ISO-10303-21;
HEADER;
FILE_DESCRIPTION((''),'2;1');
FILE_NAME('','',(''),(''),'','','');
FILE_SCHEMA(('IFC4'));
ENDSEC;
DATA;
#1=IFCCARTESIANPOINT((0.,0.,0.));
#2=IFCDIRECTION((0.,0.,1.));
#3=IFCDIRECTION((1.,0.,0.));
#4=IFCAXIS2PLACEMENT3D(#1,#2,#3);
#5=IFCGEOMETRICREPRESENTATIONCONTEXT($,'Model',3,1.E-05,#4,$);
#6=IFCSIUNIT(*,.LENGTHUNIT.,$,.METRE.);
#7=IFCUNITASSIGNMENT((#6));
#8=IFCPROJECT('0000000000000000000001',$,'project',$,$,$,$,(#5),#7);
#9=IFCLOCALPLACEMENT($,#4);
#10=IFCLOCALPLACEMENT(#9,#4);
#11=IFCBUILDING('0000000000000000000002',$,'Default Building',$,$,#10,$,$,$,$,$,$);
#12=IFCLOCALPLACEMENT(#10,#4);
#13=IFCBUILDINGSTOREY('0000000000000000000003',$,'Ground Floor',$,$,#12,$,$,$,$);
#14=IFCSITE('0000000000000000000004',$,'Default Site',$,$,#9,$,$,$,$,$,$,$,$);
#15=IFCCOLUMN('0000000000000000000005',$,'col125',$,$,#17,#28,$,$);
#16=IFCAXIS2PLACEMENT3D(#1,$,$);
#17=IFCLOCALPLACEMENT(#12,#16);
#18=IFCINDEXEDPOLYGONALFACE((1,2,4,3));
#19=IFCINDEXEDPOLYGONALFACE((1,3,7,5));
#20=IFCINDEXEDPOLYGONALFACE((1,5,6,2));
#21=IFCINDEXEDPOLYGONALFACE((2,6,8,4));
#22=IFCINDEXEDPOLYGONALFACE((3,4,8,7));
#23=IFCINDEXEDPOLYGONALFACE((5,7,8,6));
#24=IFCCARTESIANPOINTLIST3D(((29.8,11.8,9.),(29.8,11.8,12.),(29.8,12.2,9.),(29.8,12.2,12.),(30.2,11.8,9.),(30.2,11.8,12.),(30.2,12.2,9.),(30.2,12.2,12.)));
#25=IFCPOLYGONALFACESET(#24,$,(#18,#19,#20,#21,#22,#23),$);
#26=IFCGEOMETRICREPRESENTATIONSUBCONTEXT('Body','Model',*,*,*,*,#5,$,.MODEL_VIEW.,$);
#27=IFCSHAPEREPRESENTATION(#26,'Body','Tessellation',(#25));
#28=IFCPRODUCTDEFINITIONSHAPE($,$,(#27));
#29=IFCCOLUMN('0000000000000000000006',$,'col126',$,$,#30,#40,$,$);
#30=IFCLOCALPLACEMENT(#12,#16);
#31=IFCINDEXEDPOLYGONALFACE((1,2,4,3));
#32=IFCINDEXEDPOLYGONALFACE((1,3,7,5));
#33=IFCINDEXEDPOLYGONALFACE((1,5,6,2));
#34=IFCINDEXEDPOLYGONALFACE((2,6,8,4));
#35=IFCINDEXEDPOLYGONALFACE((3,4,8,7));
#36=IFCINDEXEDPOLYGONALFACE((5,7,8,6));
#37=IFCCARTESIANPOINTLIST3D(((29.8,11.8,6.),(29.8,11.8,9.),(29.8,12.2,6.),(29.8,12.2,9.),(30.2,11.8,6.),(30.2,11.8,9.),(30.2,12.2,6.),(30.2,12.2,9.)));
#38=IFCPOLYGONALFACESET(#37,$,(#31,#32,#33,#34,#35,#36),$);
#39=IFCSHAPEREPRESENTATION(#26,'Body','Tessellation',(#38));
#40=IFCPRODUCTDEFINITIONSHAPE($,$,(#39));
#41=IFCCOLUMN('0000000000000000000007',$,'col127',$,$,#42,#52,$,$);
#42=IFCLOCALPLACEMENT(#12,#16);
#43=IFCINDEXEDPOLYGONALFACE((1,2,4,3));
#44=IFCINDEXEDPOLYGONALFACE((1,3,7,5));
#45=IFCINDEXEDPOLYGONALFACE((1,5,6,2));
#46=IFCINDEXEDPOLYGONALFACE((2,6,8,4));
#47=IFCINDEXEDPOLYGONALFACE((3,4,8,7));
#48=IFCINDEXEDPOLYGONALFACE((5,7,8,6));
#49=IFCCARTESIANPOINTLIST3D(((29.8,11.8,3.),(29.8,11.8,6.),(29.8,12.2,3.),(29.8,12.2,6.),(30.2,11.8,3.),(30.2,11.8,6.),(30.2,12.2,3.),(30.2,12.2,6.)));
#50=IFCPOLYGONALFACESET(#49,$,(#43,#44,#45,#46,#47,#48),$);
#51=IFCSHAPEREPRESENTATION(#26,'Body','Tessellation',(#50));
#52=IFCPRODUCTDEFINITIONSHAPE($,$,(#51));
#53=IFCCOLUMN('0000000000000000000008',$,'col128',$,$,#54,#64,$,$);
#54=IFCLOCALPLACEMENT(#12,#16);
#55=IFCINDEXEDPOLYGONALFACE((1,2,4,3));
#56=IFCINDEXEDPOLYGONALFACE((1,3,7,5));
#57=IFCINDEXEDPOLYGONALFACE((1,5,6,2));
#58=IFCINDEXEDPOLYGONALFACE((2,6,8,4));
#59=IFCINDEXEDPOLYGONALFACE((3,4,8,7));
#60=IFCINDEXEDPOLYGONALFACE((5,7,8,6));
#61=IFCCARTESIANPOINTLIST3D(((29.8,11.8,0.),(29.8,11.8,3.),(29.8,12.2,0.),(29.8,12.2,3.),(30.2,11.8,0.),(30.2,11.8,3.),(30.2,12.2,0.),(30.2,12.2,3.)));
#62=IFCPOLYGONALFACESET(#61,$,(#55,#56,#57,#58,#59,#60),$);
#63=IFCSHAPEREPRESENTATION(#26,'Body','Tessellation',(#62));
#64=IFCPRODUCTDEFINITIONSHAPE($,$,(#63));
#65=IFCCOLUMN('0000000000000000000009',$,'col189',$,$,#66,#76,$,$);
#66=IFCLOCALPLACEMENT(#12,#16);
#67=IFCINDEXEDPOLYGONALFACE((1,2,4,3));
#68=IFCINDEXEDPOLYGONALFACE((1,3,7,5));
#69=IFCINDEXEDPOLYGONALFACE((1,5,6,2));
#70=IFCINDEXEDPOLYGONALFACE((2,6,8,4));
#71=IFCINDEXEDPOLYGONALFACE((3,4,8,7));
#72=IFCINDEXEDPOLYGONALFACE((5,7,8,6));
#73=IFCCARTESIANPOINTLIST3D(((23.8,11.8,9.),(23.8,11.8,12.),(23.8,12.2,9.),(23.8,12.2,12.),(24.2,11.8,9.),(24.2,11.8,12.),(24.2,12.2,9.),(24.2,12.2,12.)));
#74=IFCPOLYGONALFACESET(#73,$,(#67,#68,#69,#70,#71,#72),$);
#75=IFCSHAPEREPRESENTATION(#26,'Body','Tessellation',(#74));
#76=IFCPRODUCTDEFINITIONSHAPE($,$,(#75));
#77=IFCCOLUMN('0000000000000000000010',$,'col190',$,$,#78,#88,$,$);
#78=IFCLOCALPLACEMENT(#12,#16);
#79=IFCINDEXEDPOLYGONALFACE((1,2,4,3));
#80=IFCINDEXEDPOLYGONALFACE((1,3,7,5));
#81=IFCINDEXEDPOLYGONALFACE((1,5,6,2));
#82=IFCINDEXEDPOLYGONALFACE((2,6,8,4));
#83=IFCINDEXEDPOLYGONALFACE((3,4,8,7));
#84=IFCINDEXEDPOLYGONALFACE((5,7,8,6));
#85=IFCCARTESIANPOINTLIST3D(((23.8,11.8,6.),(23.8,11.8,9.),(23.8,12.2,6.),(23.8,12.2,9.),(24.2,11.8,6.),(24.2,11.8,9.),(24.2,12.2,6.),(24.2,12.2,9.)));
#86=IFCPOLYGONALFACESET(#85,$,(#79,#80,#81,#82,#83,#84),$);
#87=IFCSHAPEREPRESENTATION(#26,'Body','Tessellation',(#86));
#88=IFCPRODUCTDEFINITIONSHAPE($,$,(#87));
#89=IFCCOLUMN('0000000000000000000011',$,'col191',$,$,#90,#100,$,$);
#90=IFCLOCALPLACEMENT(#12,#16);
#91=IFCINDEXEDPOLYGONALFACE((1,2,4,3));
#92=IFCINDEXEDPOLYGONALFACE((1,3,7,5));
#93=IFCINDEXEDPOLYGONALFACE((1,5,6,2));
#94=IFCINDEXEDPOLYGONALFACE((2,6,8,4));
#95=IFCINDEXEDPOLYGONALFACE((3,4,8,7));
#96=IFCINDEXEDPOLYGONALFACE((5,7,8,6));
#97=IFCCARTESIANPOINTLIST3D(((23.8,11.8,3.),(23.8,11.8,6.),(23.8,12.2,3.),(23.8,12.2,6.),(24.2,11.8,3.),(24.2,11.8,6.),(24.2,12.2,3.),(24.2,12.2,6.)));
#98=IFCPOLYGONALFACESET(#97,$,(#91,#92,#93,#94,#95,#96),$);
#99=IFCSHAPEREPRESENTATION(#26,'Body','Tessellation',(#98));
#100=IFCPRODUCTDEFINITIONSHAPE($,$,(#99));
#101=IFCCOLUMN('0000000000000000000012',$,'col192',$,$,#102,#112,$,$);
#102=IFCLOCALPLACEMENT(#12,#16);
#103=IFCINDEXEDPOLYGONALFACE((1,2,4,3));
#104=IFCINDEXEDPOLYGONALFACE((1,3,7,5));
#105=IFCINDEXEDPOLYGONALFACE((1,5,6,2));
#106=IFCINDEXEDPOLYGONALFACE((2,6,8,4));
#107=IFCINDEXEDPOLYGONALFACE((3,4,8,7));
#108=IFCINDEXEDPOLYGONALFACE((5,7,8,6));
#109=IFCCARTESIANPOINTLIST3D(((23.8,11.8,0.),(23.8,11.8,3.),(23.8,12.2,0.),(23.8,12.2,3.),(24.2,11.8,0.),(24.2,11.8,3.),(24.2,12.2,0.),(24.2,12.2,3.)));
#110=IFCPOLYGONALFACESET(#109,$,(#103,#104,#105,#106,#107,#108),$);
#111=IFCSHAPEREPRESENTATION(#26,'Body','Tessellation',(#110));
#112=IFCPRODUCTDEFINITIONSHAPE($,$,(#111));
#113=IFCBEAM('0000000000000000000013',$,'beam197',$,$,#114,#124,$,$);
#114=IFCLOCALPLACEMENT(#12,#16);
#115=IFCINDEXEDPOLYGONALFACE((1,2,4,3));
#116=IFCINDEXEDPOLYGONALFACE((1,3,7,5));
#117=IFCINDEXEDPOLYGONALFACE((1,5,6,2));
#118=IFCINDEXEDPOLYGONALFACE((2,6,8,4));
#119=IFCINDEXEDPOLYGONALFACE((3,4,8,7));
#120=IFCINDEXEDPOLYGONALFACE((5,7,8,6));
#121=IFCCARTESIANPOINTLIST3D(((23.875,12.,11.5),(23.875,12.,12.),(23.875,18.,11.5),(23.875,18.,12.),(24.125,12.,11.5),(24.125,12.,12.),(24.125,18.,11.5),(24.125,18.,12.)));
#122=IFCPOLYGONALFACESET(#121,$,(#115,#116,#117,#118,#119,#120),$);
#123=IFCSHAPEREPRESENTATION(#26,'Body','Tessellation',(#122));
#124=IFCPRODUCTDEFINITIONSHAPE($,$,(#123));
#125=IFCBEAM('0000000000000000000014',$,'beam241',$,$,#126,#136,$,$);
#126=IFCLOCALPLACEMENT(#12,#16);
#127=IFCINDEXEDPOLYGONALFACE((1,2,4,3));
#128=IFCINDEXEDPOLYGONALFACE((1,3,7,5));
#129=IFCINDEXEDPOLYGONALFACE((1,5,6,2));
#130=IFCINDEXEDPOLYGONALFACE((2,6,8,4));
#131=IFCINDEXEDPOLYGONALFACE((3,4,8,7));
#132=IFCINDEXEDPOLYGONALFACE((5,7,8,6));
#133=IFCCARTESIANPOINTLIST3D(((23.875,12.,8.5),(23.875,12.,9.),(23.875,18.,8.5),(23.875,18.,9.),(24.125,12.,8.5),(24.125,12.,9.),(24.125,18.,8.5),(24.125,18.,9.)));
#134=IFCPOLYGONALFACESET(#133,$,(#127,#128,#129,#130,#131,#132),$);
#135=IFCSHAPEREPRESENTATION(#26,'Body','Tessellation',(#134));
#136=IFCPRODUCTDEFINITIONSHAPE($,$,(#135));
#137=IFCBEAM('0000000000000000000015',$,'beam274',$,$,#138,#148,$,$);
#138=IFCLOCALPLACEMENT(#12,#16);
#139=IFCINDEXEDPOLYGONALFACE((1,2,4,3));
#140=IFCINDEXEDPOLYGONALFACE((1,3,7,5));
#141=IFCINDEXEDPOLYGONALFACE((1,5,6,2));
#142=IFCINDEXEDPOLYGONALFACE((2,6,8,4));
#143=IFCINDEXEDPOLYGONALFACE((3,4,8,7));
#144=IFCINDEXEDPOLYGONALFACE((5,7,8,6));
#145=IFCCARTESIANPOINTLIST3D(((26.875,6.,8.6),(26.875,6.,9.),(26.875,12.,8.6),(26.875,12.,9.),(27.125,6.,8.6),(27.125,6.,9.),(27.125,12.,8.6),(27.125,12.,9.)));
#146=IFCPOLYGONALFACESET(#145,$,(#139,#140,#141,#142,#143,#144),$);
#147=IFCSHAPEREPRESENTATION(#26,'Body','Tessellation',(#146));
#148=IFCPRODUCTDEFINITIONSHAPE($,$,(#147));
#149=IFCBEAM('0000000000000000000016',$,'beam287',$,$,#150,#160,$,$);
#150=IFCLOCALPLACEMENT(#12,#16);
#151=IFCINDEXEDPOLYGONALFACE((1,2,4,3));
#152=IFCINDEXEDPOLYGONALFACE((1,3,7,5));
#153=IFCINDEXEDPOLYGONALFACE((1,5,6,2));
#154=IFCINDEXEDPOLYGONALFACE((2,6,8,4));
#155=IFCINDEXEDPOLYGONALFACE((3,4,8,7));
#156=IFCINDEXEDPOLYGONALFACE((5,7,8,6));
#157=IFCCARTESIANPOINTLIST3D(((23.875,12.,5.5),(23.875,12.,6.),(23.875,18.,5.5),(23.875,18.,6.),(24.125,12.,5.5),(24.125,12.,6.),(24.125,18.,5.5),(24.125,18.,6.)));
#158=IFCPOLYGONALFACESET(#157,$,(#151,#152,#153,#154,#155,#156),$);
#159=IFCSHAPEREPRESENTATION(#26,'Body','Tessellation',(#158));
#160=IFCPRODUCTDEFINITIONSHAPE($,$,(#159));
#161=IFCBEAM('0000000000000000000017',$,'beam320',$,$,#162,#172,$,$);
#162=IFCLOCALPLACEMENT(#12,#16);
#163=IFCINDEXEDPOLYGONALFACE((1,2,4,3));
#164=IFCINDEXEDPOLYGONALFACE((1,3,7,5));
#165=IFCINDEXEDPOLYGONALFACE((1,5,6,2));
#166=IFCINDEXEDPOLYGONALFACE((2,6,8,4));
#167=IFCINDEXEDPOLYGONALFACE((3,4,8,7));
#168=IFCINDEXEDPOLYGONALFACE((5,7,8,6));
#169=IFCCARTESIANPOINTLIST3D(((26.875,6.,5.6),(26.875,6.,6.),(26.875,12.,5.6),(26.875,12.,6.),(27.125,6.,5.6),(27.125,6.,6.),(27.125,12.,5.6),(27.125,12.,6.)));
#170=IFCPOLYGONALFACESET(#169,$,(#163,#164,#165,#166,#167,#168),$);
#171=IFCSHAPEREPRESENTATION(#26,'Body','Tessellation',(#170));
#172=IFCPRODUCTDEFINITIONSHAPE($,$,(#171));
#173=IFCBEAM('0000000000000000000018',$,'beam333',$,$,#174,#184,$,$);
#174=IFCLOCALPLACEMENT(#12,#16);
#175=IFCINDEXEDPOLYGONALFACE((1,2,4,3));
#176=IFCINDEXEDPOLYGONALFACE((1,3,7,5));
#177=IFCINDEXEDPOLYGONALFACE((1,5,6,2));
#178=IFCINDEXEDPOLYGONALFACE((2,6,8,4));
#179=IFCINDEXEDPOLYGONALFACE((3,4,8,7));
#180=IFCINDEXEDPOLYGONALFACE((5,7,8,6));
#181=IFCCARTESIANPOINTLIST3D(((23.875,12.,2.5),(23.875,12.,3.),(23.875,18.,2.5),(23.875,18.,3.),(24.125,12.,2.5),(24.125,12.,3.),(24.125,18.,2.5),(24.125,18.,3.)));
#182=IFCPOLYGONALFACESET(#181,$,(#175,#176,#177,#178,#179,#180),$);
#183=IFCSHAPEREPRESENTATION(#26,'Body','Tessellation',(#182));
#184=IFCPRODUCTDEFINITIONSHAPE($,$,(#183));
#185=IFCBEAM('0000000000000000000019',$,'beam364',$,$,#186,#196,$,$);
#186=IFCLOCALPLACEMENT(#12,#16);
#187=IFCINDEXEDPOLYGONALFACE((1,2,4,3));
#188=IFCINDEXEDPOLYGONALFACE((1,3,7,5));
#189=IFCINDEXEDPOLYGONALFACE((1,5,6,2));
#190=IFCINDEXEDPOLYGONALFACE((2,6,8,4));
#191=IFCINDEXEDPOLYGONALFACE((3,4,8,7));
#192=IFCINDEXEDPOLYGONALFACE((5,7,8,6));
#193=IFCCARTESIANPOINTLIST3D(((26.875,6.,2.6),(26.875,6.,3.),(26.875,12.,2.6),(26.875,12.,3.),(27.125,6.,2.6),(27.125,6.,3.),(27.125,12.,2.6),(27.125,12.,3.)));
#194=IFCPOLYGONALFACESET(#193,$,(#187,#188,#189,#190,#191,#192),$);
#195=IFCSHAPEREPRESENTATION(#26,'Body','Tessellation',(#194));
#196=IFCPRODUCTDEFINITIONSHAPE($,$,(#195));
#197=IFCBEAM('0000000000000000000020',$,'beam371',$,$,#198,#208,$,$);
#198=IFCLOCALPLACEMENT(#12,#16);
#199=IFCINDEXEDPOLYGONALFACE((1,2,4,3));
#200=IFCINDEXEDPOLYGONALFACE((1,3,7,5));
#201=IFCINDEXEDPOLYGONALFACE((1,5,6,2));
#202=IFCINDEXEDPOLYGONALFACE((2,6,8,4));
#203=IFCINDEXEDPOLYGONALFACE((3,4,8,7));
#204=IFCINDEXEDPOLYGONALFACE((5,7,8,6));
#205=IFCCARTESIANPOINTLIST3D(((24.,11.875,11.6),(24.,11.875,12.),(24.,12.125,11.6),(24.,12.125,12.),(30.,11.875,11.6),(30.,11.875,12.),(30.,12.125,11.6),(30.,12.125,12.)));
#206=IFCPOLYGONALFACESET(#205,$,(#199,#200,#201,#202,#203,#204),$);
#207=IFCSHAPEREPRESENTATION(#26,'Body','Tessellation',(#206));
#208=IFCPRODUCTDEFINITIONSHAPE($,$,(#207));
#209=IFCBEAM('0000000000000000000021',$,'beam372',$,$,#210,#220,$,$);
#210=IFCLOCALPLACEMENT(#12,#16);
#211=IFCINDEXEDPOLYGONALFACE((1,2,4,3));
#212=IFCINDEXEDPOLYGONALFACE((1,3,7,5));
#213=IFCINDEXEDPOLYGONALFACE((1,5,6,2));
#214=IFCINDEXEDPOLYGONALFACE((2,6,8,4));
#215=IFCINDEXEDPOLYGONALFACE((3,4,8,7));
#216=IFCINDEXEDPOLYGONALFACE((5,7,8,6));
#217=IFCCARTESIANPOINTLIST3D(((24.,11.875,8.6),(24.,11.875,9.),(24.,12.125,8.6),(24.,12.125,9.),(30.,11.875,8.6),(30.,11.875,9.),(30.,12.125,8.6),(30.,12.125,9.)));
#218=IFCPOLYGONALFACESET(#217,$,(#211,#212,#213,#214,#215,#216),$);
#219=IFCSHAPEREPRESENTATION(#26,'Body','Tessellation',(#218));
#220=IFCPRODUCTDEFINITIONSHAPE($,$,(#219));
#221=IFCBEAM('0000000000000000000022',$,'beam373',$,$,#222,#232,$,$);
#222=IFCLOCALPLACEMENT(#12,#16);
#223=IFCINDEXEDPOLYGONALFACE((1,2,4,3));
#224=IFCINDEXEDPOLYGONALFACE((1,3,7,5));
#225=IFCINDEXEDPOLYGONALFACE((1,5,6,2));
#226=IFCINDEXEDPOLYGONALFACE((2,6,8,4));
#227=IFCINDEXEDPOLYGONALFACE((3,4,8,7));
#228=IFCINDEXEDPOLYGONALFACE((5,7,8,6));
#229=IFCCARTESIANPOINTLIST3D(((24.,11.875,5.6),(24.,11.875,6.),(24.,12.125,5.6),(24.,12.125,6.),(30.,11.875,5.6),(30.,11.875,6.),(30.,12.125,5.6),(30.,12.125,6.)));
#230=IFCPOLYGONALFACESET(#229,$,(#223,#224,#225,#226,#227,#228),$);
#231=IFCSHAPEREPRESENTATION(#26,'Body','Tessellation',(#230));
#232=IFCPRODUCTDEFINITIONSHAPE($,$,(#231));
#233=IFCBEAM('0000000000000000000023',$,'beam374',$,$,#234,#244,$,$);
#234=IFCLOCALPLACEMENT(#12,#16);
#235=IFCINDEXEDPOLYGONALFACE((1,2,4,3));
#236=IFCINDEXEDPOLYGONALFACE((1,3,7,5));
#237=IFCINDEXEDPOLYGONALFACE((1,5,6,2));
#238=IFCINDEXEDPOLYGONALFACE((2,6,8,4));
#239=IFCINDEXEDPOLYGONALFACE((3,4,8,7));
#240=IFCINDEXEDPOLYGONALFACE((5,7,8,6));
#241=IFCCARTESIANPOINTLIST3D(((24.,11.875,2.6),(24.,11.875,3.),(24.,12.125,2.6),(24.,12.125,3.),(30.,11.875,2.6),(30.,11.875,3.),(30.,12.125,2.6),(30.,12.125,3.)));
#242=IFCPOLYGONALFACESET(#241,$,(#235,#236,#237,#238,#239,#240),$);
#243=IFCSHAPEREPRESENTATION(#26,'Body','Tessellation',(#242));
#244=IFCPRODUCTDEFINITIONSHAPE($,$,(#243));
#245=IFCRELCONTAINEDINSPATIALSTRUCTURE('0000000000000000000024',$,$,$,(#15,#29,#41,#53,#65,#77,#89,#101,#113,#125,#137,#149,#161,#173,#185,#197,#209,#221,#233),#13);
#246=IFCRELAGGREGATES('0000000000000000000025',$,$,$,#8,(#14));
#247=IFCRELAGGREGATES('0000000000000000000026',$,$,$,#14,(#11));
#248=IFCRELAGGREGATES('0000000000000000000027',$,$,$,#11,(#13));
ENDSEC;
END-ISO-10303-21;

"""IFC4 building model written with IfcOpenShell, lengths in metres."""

from ifc_helpers import new_model, si_unit, frame, origin_with_axes, place, context, subcontext, project, spatial, indexed_curve, outline, extrude, element, save


model = new_model("IFC4")

# Units and contexts
model_context = context("Model", 3, precision=1e-05, world=origin_with_axes())
body_context = subcontext(model_context, "Body", "Model", "MODEL_VIEW")
ifc_project = project(units=[si_unit("LENGTHUNIT", "METRE")], contexts=[model_context])

# Site, building, storey
site_placement = place(None, origin_with_axes())
site = spatial("IfcSite", under=ifc_project, at=site_placement, Name="Default Site")
building_placement = place(site_placement, origin_with_axes())
building = spatial("IfcBuilding", under=site, at=building_placement, Name="Default Building")
storey_placement = place(building_placement, origin_with_axes())
storey = spatial("IfcBuildingStorey", under=building, at=storey_placement, Name="Ground Floor")

# Columns
for number, where, z_axis, x_axis, name in (
    (1, (29.8, 11.8, 9.0), (0.0, 0.0, 1.0), (1.0, 0.0, 0.0), "col125"),
    (2, (29.8, 11.8, 6.0), (0.0, 0.0, 1.0), (1.0, 0.0, 0.0), "col126"),
    (3, (29.8, 11.8, 3.0), (0.0, 0.0, 1.0), (1.0, 0.0, 0.0), "col127"),
    (4, (29.8, 11.8, 0.0), (0.0, 0.0, 1.0), (1.0, 0.0, 0.0), "col128"),
    (5, (23.8, 11.8, 9.0), (0.0, 0.0, 1.0), (1.0, 0.0, 0.0), "col189"),
    (6, (23.8, 11.8, 6.0), (0.0, 0.0, 1.0), (1.0, 0.0, 0.0), "col190"),
    (7, (23.8, 11.8, 3.0), (0.0, 0.0, 1.0), (1.0, 0.0, 0.0), "col191"),
    (8, (23.8, 11.8, 0.0), (0.0, 0.0, 1.0), (1.0, 0.0, 0.0), "col192"),
):
    element("IfcColumn", number, at=place(storey_placement, frame(where, z_axis=z_axis, x_axis=x_axis)), inside=storey, Name=name, context=body_context, shape_type="SweptSolid", body=[
        extrude(outline(indexed_curve([(0.0, 0.0), (0.0, 0.4), (0.4, 0.4), (0.4, 0.0), (0.0, 0.0)], self_intersect=False)), origin_with_axes(), (0.0, 0.0, 1.0), 3.0),
    ])

# Beams
for number, where, z_axis, x_axis, name in (
    (9, (24.125, 12.0, 11.5), (0.0, 0.0, 1.0), (0.0, 1.0, 0.0), "beam197"),
    (10, (24.125, 12.0, 8.5), (0.0, 0.0, 1.0), (0.0, 1.0, 0.0), "beam241"),
):
    element("IfcBeam", number, at=place(storey_placement, frame(where, z_axis=z_axis, x_axis=x_axis)), inside=storey, Name=name, context=body_context, shape_type="SweptSolid", body=[
        extrude(outline(indexed_curve([(0.0, 0.0), (0.0, 0.25), (6.0, 0.25), (6.0, 0.0), (0.0, 0.0)], self_intersect=False)), origin_with_axes(), (0.0, 0.0, 1.0), 0.5),
    ])
beam_1_placement = place(storey_placement, frame((26.875, 12.0, 8.6), z_axis=(0.0, 0.0, 1.0), x_axis=(0.0, -1.0, 0.0)))
element("IfcBeam", 11, at=beam_1_placement, inside=storey, Name="beam274", context=body_context, shape_type="SweptSolid", body=[
    extrude(outline(indexed_curve([(0.0, 0.0), (0.0, 0.25), (6.0, 0.25), (6.0, 0.0), (0.0, 0.0)], self_intersect=False)), origin_with_axes(), (0.0, 0.0, 1.0), 0.4),
])
beam_2_placement = place(storey_placement, frame((24.125, 12.0, 5.5), z_axis=(0.0, 0.0, 1.0), x_axis=(0.0, 1.0, 0.0)))
element("IfcBeam", 12, at=beam_2_placement, inside=storey, Name="beam287", context=body_context, shape_type="SweptSolid", body=[
    extrude(outline(indexed_curve([(0.0, 0.0), (0.0, 0.25), (6.0, 0.25), (6.0, 0.0), (0.0, 0.0)], self_intersect=False)), origin_with_axes(), (0.0, 0.0, 1.0), 0.5),
])
beam_3_placement = place(storey_placement, frame((26.875, 12.0, 5.6), z_axis=(0.0, 0.0, 1.0), x_axis=(0.0, -1.0, 0.0)))
element("IfcBeam", 13, at=beam_3_placement, inside=storey, Name="beam320", context=body_context, shape_type="SweptSolid", body=[
    extrude(outline(indexed_curve([(0.0, 0.0), (0.0, 0.25), (6.0, 0.25), (6.0, 0.0), (0.0, 0.0)], self_intersect=False)), origin_with_axes(), (0.0, 0.0, 1.0), 0.4),
])
beam_4_placement = place(storey_placement, frame((24.125, 12.0, 2.5), z_axis=(0.0, 0.0, 1.0), x_axis=(0.0, 1.0, 0.0)))
element("IfcBeam", 14, at=beam_4_placement, inside=storey, Name="beam333", context=body_context, shape_type="SweptSolid", body=[
    extrude(outline(indexed_curve([(0.0, 0.0), (0.0, 0.25), (6.0, 0.25), (6.0, 0.0), (0.0, 0.0)], self_intersect=False)), origin_with_axes(), (0.0, 0.0, 1.0), 0.5),
])
for number, where, z_axis, x_axis, name in (
    (15, (26.875, 12.0, 2.6), (0.0, 0.0, 1.0), (0.0, -1.0, 0.0), "beam364"),
    (16, (24.0, 11.875, 11.6), (0.0, 0.0, 1.0), (1.0, 0.0, 0.0), "beam371"),
    (17, (24.0, 11.875, 8.6), (0.0, 0.0, 1.0), (1.0, 0.0, 0.0), "beam372"),
    (18, (24.0, 11.875, 5.6), (0.0, 0.0, 1.0), (1.0, 0.0, 0.0), "beam373"),
    (19, (24.0, 11.875, 2.6), (0.0, 0.0, 1.0), (1.0, 0.0, 0.0), "beam374"),
):
    element("IfcBeam", number, at=place(storey_placement, frame(where, z_axis=z_axis, x_axis=x_axis)), inside=storey, Name=name, context=body_context, shape_type="SweptSolid", body=[
        extrude(outline(indexed_curve([(0.0, 0.0), (0.0, 0.25), (6.0, 0.25), (6.0, 0.0), (0.0, 0.0)], self_intersect=False)), origin_with_axes(), (0.0, 0.0, 1.0), 0.4),
    ])

save(model, "model.ifc")
